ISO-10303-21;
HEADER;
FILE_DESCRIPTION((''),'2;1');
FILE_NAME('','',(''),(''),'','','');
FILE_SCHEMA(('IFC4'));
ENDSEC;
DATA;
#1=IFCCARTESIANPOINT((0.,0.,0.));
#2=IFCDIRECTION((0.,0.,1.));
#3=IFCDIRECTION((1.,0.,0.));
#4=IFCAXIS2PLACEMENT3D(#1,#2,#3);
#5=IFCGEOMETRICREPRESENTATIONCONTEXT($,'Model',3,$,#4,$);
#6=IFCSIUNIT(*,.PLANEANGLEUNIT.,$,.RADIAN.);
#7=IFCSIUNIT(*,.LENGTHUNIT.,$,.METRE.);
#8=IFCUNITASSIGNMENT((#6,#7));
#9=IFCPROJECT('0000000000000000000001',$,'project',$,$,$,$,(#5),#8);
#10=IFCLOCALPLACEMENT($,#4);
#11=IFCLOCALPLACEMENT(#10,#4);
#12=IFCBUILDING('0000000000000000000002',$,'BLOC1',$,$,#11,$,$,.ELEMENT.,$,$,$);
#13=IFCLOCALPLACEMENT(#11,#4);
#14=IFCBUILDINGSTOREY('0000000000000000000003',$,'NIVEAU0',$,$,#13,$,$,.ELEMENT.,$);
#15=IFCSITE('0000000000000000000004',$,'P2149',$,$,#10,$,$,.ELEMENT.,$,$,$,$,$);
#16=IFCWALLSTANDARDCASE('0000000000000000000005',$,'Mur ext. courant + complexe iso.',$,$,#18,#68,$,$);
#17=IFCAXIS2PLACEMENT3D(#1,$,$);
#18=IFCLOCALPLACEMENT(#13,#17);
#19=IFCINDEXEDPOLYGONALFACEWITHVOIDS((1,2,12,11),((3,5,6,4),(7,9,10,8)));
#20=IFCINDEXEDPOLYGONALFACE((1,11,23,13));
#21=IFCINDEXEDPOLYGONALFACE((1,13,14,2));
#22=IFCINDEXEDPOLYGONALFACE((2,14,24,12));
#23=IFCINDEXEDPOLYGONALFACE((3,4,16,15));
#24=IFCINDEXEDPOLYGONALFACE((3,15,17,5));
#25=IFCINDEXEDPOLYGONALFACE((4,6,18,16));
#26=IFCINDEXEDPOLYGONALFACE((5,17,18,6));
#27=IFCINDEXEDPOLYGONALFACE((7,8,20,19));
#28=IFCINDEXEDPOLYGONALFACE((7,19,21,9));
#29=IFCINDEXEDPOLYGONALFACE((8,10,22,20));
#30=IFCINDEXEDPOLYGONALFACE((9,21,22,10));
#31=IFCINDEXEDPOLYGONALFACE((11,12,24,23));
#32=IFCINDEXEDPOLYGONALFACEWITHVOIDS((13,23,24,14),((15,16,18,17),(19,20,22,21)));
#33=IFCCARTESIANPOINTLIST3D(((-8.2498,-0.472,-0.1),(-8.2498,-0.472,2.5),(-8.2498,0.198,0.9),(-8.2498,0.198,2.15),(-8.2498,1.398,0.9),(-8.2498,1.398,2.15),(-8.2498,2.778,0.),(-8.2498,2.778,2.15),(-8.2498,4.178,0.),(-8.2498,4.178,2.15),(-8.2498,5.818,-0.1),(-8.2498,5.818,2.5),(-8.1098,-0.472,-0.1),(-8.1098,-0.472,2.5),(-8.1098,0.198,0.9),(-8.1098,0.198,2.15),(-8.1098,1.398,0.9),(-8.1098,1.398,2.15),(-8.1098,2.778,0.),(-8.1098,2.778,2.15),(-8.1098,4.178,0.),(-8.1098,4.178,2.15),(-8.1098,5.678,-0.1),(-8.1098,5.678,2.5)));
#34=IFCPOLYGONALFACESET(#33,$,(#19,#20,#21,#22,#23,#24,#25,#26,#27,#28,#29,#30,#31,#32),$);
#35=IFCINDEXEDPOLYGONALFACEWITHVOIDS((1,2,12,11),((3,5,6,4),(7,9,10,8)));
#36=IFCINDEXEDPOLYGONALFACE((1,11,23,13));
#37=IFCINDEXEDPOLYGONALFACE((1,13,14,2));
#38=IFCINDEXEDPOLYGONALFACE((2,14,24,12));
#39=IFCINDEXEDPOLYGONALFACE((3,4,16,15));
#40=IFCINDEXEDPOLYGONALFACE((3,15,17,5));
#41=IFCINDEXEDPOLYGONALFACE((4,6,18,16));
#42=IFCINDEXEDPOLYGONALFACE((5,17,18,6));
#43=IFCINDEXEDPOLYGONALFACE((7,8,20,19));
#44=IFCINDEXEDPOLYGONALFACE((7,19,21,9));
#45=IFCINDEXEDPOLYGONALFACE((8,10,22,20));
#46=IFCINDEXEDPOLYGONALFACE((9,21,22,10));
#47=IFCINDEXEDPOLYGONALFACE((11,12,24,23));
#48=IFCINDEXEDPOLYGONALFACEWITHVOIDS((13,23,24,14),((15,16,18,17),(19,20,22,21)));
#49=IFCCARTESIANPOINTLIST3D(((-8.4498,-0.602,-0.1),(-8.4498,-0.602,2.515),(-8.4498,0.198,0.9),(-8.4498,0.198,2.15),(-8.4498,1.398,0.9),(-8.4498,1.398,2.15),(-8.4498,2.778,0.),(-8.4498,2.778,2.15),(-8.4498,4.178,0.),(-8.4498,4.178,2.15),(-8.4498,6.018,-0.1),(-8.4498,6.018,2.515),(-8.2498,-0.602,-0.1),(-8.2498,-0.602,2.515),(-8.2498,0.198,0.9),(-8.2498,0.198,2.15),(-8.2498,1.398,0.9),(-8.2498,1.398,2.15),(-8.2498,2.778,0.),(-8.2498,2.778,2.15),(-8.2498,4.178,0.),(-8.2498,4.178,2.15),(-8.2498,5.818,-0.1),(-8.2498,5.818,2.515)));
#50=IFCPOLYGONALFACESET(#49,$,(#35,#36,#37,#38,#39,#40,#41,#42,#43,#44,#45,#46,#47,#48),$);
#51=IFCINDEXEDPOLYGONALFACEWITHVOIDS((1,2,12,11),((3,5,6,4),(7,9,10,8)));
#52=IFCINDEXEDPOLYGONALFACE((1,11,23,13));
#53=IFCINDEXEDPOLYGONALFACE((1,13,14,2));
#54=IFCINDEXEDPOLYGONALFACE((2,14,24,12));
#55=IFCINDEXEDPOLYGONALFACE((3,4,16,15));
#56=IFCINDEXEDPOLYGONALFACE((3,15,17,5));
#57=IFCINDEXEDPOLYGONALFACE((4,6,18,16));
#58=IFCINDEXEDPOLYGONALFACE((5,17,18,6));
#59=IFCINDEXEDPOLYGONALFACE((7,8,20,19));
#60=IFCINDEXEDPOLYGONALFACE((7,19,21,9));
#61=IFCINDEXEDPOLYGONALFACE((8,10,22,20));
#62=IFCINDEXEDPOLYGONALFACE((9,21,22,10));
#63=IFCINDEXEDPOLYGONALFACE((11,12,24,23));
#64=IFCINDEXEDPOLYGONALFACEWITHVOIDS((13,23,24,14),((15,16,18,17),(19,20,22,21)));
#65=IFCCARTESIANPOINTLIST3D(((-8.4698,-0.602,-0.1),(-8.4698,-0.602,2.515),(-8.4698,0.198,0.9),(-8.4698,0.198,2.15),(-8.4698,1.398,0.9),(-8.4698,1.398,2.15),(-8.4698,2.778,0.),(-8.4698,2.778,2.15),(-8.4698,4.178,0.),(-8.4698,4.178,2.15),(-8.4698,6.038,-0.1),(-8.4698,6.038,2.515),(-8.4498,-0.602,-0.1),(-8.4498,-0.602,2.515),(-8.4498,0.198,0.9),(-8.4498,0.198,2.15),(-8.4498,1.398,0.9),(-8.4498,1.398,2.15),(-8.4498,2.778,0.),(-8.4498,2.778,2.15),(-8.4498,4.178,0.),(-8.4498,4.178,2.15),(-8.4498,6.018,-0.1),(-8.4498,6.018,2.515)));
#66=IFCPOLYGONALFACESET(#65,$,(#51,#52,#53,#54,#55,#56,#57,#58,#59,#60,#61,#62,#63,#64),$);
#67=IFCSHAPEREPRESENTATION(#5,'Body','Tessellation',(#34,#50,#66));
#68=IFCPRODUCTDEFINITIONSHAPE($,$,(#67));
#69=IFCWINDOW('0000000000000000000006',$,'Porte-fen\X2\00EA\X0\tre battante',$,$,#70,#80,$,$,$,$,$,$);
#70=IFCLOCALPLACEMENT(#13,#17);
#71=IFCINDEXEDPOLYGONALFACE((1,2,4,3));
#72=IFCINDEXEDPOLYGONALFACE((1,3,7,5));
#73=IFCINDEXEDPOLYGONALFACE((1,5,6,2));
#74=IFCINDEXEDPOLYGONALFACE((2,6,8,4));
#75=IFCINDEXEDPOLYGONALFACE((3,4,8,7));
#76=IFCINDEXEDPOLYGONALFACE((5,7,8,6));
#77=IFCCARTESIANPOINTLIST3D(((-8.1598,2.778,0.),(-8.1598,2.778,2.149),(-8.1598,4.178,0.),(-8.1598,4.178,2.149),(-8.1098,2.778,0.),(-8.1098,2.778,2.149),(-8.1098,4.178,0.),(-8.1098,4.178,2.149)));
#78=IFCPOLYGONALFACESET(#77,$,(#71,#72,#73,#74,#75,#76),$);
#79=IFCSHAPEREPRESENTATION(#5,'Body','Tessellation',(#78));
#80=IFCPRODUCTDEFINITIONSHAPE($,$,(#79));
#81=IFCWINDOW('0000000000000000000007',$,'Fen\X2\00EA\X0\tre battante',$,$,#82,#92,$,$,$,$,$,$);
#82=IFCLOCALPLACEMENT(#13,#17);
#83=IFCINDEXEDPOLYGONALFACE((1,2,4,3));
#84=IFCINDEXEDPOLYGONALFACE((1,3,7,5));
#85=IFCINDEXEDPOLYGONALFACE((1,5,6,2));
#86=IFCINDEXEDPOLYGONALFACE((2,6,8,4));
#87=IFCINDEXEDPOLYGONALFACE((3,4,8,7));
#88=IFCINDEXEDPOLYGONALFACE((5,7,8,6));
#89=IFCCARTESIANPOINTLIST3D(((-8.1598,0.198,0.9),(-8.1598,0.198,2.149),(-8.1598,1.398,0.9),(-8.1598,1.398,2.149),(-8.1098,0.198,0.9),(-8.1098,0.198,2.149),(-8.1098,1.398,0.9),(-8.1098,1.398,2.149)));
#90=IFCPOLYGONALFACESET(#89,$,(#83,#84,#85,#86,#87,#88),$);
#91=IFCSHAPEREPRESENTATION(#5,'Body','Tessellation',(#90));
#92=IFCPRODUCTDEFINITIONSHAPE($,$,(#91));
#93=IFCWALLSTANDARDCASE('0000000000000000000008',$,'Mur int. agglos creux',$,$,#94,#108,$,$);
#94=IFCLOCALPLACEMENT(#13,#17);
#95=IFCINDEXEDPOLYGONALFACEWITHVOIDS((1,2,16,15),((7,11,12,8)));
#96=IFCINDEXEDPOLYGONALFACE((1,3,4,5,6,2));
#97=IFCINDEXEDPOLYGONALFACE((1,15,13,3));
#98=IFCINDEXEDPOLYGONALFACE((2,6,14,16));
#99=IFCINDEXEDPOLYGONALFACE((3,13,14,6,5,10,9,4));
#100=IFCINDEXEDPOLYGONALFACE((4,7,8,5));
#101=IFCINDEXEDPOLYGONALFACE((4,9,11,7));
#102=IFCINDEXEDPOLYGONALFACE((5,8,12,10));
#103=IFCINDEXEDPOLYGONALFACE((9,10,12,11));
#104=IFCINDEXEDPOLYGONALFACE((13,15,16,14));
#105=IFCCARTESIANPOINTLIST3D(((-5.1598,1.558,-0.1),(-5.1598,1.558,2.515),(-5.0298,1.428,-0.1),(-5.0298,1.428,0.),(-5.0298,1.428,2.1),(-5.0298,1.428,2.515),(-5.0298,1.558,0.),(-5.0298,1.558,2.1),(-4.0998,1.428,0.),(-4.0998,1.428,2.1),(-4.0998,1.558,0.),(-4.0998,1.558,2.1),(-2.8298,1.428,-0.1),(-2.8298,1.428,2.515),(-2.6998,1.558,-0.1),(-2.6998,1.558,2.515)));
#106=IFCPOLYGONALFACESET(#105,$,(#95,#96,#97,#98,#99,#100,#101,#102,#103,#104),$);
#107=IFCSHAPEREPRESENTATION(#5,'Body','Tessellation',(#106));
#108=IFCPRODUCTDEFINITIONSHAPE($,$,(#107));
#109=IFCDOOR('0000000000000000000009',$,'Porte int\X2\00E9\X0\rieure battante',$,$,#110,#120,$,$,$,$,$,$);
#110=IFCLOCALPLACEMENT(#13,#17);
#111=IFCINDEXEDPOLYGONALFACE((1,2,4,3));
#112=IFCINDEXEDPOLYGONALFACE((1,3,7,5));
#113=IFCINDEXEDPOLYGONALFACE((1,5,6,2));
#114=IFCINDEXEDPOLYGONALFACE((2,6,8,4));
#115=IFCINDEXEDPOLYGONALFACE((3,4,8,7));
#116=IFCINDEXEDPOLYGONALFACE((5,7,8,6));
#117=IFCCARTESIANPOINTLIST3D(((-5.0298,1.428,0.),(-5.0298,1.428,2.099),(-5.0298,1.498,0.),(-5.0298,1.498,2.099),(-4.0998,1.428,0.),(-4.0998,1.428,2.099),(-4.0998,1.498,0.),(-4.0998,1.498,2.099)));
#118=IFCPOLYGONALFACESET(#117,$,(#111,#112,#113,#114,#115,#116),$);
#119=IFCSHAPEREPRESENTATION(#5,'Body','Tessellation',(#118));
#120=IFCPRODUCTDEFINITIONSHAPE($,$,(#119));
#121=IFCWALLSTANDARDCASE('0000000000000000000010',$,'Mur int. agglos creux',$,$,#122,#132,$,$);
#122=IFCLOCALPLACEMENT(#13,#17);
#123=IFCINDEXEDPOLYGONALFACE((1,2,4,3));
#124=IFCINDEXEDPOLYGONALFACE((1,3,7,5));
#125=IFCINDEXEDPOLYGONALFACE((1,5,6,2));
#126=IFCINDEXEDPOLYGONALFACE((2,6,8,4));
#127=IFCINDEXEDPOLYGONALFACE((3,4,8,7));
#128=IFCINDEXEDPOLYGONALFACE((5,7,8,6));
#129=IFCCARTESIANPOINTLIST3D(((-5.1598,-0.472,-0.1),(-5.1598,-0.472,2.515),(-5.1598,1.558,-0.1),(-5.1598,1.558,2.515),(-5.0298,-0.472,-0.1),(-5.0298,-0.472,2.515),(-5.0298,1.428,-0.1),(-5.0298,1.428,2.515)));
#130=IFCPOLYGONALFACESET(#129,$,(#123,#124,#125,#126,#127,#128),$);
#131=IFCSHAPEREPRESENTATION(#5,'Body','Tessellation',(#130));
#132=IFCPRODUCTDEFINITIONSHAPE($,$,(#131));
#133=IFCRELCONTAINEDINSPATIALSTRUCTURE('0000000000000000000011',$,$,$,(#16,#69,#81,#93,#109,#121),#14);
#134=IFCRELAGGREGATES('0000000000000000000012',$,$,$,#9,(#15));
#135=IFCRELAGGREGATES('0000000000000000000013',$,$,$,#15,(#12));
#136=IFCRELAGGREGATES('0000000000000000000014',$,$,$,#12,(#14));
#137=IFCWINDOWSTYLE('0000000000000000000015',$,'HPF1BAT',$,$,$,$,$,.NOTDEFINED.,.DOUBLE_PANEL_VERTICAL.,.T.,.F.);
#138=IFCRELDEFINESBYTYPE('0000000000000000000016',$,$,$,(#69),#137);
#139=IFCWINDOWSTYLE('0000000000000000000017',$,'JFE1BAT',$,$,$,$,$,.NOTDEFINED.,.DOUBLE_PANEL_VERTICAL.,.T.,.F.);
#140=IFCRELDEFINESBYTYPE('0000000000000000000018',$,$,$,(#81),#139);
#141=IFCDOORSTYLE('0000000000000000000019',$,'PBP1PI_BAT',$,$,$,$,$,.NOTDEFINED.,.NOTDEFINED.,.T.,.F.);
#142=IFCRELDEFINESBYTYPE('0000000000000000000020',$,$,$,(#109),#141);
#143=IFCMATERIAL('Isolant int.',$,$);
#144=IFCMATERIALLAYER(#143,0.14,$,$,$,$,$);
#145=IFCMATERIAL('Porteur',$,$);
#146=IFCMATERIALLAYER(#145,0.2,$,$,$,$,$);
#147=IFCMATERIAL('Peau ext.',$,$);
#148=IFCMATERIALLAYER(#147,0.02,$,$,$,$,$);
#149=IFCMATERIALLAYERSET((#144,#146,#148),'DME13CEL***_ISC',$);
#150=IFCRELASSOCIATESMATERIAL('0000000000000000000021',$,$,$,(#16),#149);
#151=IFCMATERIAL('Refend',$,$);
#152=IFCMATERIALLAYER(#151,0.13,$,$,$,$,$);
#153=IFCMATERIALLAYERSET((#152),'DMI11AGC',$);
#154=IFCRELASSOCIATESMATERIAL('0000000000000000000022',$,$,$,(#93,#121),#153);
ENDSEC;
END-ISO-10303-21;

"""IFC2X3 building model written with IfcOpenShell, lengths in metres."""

from ifc_helpers import new_model, si_unit, point, frame, frame_2d, origin_with_axes, place, context, project, spatial, line_curve, trimmed, segment, composite_curve, rectangle, outline, extrude, clip, bounded_halfspace, material, layer, layer_set, layer_usage, type_object, element, fill, save


model = new_model("IFC2X3")

# Units and contexts
model_context = context("Model", 3, world=origin_with_axes())
ifc_project = project(units=[si_unit("PLANEANGLEUNIT", "RADIAN"), si_unit("LENGTHUNIT", "METRE")], contexts=[model_context])

# Site, building, storey
site_placement = place(None, origin_with_axes())
site = spatial("IfcSite", under=ifc_project, at=site_placement, Name="P2149", CompositionType="ELEMENT")
building_placement = place(site_placement, origin_with_axes())
building = spatial("IfcBuilding", under=site, at=building_placement, Name="BLOC1", CompositionType="ELEMENT")
storey_placement = place(building_placement, origin_with_axes())
storey = spatial("IfcBuildingStorey", under=building, at=storey_placement, Name="NIVEAU0", CompositionType="ELEMENT")

# Shared definitions
ifc_material_1 = material(Name="Isolant int.")
ifc_layer_1 = layer(ifc_material_1, 0.14)
ifc_material_2 = material(Name="Porteur")
ifc_layer_2 = layer(ifc_material_2, 0.2)
ifc_material_3 = material(Name="Peau ext.")
ifc_layer_3 = layer(ifc_material_3, 0.02)
ifc_layer_set_1 = layer_set([ifc_layer_1, ifc_layer_2, ifc_layer_3], Name="DME13CEL***_ISC")
ifc_layer_usage_1 = layer_usage(ifc_layer_set_1, "AXIS2", "POSITIVE", 0.0)

# Shared definitions
ifc_material_4 = material(Name="Refend")
ifc_layer_4 = layer(ifc_material_4, 0.13)
ifc_layer_set_2 = layer_set([ifc_layer_4], Name="DMI11AGC")
ifc_layer_usage_2 = layer_usage(ifc_layer_set_2, "AXIS2", "POSITIVE", 0.0)

# Wall, openings, windows
wall_1_placement = place(storey_placement, frame((-8.1098, -0.472, -0.1), z_axis=(0.0, 0.0, 1.0), x_axis=(0.0, 1.0, 0.0)))
wall_1 = element("IfcWallStandardCase", 1, at=wall_1_placement, inside=storey, material=ifc_layer_usage_1, Name="Mur ext. courant + complexe iso.", context=model_context, shape_type="Clipping", body=[
    clip(extrude(outline(composite_curve([segment(trimmed(line_curve((0.0, 0.0), (1.0, 0.0), 6.15), [point((0.0, 0.0))], [point((6.15, 0.0))], True, "CARTESIAN"), True, "CONTINUOUS"), segment(trimmed(line_curve((6.15, 0.0), (0.707107, 0.707107), 0.19799), [point((6.15, 0.0))], [point((6.29, 0.14))], True, "CARTESIAN"), True, "CONTINUOUS"), segment(trimmed(line_curve((6.29, 0.14), (-1.0, 0.0), 6.29), [point((6.29, 0.14))], [point((0.0, 0.14))], True, "CARTESIAN"), True, "CONTINUOUS"), segment(trimmed(line_curve((0.0, 0.14), (0.0, -1.0), 0.14), [point((0.0, 0.14))], [point((0.0, 0.0))], True, "CARTESIAN"), True, "CONTINUOUS")], self_intersect=False)), origin_with_axes(), (0.0, 0.0, 1.0), 2.615), bounded_halfspace(frame((0.0, 0.0, 2.6), z_axis=(0.0, 0.0, 1.0), x_axis=(0.0, 1.0, 0.0)), False, frame((0.0, 0.0, 2.6), z_axis=(0.0, 0.0, 1.0), x_axis=(1.0, 0.0, 0.0)), composite_curve([segment(trimmed(line_curve((0.0, 0.0), (1.0, 0.0), 6.15), [point((0.0, 0.0))], [point((6.15, 0.0))], True, "CARTESIAN"), True, "CONTINUOUS"), segment(trimmed(line_curve((6.15, 0.0), (0.707107, 0.707107), 0.19799), [point((6.15, 0.0))], [point((6.29, 0.14))], True, "CARTESIAN"), True, "CONTINUOUS"), segment(trimmed(line_curve((6.29, 0.14), (-1.0, 0.0), 6.29), [point((6.29, 0.14))], [point((0.0, 0.14))], True, "CARTESIAN"), True, "CONTINUOUS"), segment(trimmed(line_curve((0.0, 0.14), (0.0, -1.0), 0.14), [point((0.0, 0.14))], [point((0.0, 0.0))], True, "CARTESIAN"), True, "CONTINUOUS")], self_intersect=False))),
    extrude(outline(composite_curve([segment(trimmed(line_curve((-0.13, 0.14), (1.0, 0.0), 6.42), [point((-0.13, 0.14))], [point((6.29, 0.14))], True, "CARTESIAN"), True, "CONTINUOUS"), segment(trimmed(line_curve((6.29, 0.14), (0.707107, 0.707107), 0.282843), [point((6.29, 0.14))], [point((6.49, 0.34))], True, "CARTESIAN"), True, "CONTINUOUS"), segment(trimmed(line_curve((6.49, 0.34), (-1.0, 0.0), 6.62), [point((6.49, 0.34))], [point((-0.13, 0.34))], True, "CARTESIAN"), True, "CONTINUOUS"), segment(trimmed(line_curve((-0.13, 0.34), (0.0, -1.0), 0.2), [point((-0.13, 0.34))], [point((-0.13, 0.14))], True, "CARTESIAN"), True, "CONTINUOUS")], self_intersect=False)), origin_with_axes(), (0.0, 0.0, 1.0), 2.615),
    extrude(outline(composite_curve([segment(trimmed(line_curve((-0.13, 0.34), (1.0, 0.0), 6.62), [point((-0.13, 0.34))], [point((6.49, 0.34))], True, "CARTESIAN"), True, "CONTINUOUS"), segment(trimmed(line_curve((6.49, 0.34), (0.707107, 0.707107), 0.028284), [point((6.49, 0.34))], [point((6.51, 0.36))], True, "CARTESIAN"), True, "CONTINUOUS"), segment(trimmed(line_curve((6.51, 0.36), (-1.0, 0.0), 6.64), [point((6.51, 0.36))], [point((-0.13, 0.36))], True, "CARTESIAN"), True, "CONTINUOUS"), segment(trimmed(line_curve((-0.13, 0.36), (0.0, -1.0), 0.02), [point((-0.13, 0.36))], [point((-0.13, 0.34))], True, "CARTESIAN"), True, "CONTINUOUS")], self_intersect=False)), origin_with_axes(), (0.0, 0.0, 1.0), 2.615),
])
opening_1_placement = place(wall_1_placement, frame((3.25, 0.0, 0.1), z_axis=(0.0, -1.0, 0.0), x_axis=(1.0, 0.0, 0.0)))
opening_1 = element("IfcOpeningElement", 2, at=opening_1_placement, cuts=wall_1, context=model_context, shape_type="SweptSolid", body=[
    extrude(rectangle(XDim=1.4, YDim=2.15, at=frame_2d((0.7, 1.075), x_axis=(1.0, 0.0))), origin_with_axes(), (0.0, 0.0, -1.0), 0.36),
])
opening_2_placement = place(wall_1_placement, frame((1.87, 0.0, 1.0), z_axis=(0.0, 1.0, 0.0), x_axis=(-1.0, 0.0, 0.0)))
opening_2 = element("IfcOpeningElement", 3, at=opening_2_placement, cuts=wall_1, context=model_context, shape_type="SweptSolid", body=[
    extrude(rectangle(XDim=1.2, YDim=1.25, at=frame_2d((0.6, 0.625), x_axis=(1.0, 0.0))), origin_with_axes(), (0.0, 0.0, 1.0), 0.36),
])
window_style_1 = type_object("IfcWindowStyle", Name="HPF1BAT", ConstructionType="NOTDEFINED", OperationType="DOUBLE_PANEL_VERTICAL", ParameterTakesPrecedence=True, Sizeable=False)
window_1_placement = place(opening_1_placement, origin_with_axes())
window_1 = element("IfcWindow", 4, at=window_1_placement, inside=storey, type_object=window_style_1, Name="Porte-fenêtre battante", context=model_context, shape_type="SweptSolid", body=[
    extrude(rectangle(XDim=1.4, YDim=2.149, at=frame_2d((0.7, 1.0745), x_axis=(1.0, 0.0))), origin_with_axes(), (0.0, 0.0, -1.0), 0.05),
])
fill(opening_1, window_1)
window_style_2 = type_object("IfcWindowStyle", Name="JFE1BAT", ConstructionType="NOTDEFINED", OperationType="DOUBLE_PANEL_VERTICAL", ParameterTakesPrecedence=True, Sizeable=False)
window_2_placement = place(opening_2_placement, origin_with_axes())
window_2 = element("IfcWindow", 5, at=window_2_placement, inside=storey, type_object=window_style_2, Name="Fenêtre battante", context=model_context, shape_type="SweptSolid", body=[
    extrude(rectangle(XDim=1.2, YDim=1.249, at=frame_2d((0.6, 0.6245), x_axis=(1.0, 0.0))), origin_with_axes(), (0.0, 0.0, 1.0), 0.05),
])
fill(opening_2, window_2)

# Wall, opening, door
wall_2_placement = place(storey_placement, frame((-2.6998, 1.558, -0.1), z_axis=(0.0, 0.0, 1.0), x_axis=(-1.0, 0.0, 0.0)))
wall_2 = element("IfcWallStandardCase", 6, at=wall_2_placement, inside=storey, material=ifc_layer_usage_2, Name="Mur int. agglos creux", context=model_context, shape_type="SweptSolid", body=[
    extrude(outline(composite_curve([segment(trimmed(line_curve((0.0, 0.0), (1.0, 0.0), 2.46), [point((0.0, 0.0))], [point((2.46, 0.0))], True, "CARTESIAN"), True, "CONTINUOUS"), segment(trimmed(line_curve((2.46, 0.0), (-0.707107, 0.707107), 0.183848), [point((2.46, 0.0))], [point((2.33, 0.13))], True, "CARTESIAN"), True, "CONTINUOUS"), segment(trimmed(line_curve((2.33, 0.13), (-1.0, 0.0), 2.2), [point((2.33, 0.13))], [point((0.13, 0.13))], True, "CARTESIAN"), True, "CONTINUOUS"), segment(trimmed(line_curve((0.13, 0.13), (-0.707107, -0.707107), 0.183848), [point((0.13, 0.13))], [point((0.0, 0.0))], True, "CARTESIAN"), True, "CONTINUOUS")], self_intersect=False)), origin_with_axes(), (0.0, 0.0, 1.0), 2.615),
])
opening_3_placement = place(wall_2_placement, frame((1.4, 0.13, 0.1), z_axis=(0.0, -1.0, 0.0), x_axis=(1.0, 0.0, 0.0)))
opening_3 = element("IfcOpeningElement", 7, at=opening_3_placement, cuts=wall_2, context=model_context, shape_type="SweptSolid", body=[
    extrude(rectangle(XDim=0.93, YDim=2.1, at=frame_2d((0.465, 1.05), x_axis=(1.0, 0.0))), origin_with_axes(), (0.0, 0.0, 1.0), 0.13),
])
door_style_1 = type_object("IfcDoorStyle", Name="PBP1PI_BAT", ConstructionType="NOTDEFINED", OperationType="NOTDEFINED", ParameterTakesPrecedence=True, Sizeable=False)
door_1_placement = place(opening_3_placement, origin_with_axes())
door_1 = element("IfcDoor", 8, at=door_1_placement, inside=storey, type_object=door_style_1, Name="Porte intérieure battante", context=model_context, shape_type="SweptSolid", body=[
    extrude(rectangle(XDim=0.93, YDim=2.099, at=frame_2d((0.465, 1.0495), x_axis=(1.0, 0.0))), origin_with_axes(), (0.0, 0.0, 1.0), 0.07),
])
fill(opening_3, door_1)

# Wall
wall_3_placement = place(storey_placement, frame((-5.1598, 1.558, -0.1), z_axis=(0.0, 0.0, 1.0), x_axis=(0.0, -1.0, 0.0)))
element("IfcWallStandardCase", 9, at=wall_3_placement, inside=storey, material=ifc_layer_usage_2, Name="Mur int. agglos creux", context=model_context, shape_type="SweptSolid", body=[
    extrude(outline(composite_curve([segment(trimmed(line_curve((0.0, 0.0), (1.0, 0.0), 2.03), [point((0.0, 0.0))], [point((2.03, 0.0))], True, "CARTESIAN"), True, "CONTINUOUS"), segment(trimmed(line_curve((2.03, 0.0), (0.0, 1.0), 0.13), [point((2.03, 0.0))], [point((2.03, 0.13))], True, "CARTESIAN"), True, "CONTINUOUS"), segment(trimmed(line_curve((2.03, 0.13), (-1.0, 0.0), 1.9), [point((2.03, 0.13))], [point((0.13, 0.13))], True, "CARTESIAN"), True, "CONTINUOUS"), segment(trimmed(line_curve((0.13, 0.13), (-0.707107, -0.707107), 0.183848), [point((0.13, 0.13))], [point((0.0, 0.0))], True, "CARTESIAN"), True, "CONTINUOUS")], self_intersect=False)), origin_with_axes(), (0.0, 0.0, 1.0), 2.615),
])

save(model, "model.ifc")
